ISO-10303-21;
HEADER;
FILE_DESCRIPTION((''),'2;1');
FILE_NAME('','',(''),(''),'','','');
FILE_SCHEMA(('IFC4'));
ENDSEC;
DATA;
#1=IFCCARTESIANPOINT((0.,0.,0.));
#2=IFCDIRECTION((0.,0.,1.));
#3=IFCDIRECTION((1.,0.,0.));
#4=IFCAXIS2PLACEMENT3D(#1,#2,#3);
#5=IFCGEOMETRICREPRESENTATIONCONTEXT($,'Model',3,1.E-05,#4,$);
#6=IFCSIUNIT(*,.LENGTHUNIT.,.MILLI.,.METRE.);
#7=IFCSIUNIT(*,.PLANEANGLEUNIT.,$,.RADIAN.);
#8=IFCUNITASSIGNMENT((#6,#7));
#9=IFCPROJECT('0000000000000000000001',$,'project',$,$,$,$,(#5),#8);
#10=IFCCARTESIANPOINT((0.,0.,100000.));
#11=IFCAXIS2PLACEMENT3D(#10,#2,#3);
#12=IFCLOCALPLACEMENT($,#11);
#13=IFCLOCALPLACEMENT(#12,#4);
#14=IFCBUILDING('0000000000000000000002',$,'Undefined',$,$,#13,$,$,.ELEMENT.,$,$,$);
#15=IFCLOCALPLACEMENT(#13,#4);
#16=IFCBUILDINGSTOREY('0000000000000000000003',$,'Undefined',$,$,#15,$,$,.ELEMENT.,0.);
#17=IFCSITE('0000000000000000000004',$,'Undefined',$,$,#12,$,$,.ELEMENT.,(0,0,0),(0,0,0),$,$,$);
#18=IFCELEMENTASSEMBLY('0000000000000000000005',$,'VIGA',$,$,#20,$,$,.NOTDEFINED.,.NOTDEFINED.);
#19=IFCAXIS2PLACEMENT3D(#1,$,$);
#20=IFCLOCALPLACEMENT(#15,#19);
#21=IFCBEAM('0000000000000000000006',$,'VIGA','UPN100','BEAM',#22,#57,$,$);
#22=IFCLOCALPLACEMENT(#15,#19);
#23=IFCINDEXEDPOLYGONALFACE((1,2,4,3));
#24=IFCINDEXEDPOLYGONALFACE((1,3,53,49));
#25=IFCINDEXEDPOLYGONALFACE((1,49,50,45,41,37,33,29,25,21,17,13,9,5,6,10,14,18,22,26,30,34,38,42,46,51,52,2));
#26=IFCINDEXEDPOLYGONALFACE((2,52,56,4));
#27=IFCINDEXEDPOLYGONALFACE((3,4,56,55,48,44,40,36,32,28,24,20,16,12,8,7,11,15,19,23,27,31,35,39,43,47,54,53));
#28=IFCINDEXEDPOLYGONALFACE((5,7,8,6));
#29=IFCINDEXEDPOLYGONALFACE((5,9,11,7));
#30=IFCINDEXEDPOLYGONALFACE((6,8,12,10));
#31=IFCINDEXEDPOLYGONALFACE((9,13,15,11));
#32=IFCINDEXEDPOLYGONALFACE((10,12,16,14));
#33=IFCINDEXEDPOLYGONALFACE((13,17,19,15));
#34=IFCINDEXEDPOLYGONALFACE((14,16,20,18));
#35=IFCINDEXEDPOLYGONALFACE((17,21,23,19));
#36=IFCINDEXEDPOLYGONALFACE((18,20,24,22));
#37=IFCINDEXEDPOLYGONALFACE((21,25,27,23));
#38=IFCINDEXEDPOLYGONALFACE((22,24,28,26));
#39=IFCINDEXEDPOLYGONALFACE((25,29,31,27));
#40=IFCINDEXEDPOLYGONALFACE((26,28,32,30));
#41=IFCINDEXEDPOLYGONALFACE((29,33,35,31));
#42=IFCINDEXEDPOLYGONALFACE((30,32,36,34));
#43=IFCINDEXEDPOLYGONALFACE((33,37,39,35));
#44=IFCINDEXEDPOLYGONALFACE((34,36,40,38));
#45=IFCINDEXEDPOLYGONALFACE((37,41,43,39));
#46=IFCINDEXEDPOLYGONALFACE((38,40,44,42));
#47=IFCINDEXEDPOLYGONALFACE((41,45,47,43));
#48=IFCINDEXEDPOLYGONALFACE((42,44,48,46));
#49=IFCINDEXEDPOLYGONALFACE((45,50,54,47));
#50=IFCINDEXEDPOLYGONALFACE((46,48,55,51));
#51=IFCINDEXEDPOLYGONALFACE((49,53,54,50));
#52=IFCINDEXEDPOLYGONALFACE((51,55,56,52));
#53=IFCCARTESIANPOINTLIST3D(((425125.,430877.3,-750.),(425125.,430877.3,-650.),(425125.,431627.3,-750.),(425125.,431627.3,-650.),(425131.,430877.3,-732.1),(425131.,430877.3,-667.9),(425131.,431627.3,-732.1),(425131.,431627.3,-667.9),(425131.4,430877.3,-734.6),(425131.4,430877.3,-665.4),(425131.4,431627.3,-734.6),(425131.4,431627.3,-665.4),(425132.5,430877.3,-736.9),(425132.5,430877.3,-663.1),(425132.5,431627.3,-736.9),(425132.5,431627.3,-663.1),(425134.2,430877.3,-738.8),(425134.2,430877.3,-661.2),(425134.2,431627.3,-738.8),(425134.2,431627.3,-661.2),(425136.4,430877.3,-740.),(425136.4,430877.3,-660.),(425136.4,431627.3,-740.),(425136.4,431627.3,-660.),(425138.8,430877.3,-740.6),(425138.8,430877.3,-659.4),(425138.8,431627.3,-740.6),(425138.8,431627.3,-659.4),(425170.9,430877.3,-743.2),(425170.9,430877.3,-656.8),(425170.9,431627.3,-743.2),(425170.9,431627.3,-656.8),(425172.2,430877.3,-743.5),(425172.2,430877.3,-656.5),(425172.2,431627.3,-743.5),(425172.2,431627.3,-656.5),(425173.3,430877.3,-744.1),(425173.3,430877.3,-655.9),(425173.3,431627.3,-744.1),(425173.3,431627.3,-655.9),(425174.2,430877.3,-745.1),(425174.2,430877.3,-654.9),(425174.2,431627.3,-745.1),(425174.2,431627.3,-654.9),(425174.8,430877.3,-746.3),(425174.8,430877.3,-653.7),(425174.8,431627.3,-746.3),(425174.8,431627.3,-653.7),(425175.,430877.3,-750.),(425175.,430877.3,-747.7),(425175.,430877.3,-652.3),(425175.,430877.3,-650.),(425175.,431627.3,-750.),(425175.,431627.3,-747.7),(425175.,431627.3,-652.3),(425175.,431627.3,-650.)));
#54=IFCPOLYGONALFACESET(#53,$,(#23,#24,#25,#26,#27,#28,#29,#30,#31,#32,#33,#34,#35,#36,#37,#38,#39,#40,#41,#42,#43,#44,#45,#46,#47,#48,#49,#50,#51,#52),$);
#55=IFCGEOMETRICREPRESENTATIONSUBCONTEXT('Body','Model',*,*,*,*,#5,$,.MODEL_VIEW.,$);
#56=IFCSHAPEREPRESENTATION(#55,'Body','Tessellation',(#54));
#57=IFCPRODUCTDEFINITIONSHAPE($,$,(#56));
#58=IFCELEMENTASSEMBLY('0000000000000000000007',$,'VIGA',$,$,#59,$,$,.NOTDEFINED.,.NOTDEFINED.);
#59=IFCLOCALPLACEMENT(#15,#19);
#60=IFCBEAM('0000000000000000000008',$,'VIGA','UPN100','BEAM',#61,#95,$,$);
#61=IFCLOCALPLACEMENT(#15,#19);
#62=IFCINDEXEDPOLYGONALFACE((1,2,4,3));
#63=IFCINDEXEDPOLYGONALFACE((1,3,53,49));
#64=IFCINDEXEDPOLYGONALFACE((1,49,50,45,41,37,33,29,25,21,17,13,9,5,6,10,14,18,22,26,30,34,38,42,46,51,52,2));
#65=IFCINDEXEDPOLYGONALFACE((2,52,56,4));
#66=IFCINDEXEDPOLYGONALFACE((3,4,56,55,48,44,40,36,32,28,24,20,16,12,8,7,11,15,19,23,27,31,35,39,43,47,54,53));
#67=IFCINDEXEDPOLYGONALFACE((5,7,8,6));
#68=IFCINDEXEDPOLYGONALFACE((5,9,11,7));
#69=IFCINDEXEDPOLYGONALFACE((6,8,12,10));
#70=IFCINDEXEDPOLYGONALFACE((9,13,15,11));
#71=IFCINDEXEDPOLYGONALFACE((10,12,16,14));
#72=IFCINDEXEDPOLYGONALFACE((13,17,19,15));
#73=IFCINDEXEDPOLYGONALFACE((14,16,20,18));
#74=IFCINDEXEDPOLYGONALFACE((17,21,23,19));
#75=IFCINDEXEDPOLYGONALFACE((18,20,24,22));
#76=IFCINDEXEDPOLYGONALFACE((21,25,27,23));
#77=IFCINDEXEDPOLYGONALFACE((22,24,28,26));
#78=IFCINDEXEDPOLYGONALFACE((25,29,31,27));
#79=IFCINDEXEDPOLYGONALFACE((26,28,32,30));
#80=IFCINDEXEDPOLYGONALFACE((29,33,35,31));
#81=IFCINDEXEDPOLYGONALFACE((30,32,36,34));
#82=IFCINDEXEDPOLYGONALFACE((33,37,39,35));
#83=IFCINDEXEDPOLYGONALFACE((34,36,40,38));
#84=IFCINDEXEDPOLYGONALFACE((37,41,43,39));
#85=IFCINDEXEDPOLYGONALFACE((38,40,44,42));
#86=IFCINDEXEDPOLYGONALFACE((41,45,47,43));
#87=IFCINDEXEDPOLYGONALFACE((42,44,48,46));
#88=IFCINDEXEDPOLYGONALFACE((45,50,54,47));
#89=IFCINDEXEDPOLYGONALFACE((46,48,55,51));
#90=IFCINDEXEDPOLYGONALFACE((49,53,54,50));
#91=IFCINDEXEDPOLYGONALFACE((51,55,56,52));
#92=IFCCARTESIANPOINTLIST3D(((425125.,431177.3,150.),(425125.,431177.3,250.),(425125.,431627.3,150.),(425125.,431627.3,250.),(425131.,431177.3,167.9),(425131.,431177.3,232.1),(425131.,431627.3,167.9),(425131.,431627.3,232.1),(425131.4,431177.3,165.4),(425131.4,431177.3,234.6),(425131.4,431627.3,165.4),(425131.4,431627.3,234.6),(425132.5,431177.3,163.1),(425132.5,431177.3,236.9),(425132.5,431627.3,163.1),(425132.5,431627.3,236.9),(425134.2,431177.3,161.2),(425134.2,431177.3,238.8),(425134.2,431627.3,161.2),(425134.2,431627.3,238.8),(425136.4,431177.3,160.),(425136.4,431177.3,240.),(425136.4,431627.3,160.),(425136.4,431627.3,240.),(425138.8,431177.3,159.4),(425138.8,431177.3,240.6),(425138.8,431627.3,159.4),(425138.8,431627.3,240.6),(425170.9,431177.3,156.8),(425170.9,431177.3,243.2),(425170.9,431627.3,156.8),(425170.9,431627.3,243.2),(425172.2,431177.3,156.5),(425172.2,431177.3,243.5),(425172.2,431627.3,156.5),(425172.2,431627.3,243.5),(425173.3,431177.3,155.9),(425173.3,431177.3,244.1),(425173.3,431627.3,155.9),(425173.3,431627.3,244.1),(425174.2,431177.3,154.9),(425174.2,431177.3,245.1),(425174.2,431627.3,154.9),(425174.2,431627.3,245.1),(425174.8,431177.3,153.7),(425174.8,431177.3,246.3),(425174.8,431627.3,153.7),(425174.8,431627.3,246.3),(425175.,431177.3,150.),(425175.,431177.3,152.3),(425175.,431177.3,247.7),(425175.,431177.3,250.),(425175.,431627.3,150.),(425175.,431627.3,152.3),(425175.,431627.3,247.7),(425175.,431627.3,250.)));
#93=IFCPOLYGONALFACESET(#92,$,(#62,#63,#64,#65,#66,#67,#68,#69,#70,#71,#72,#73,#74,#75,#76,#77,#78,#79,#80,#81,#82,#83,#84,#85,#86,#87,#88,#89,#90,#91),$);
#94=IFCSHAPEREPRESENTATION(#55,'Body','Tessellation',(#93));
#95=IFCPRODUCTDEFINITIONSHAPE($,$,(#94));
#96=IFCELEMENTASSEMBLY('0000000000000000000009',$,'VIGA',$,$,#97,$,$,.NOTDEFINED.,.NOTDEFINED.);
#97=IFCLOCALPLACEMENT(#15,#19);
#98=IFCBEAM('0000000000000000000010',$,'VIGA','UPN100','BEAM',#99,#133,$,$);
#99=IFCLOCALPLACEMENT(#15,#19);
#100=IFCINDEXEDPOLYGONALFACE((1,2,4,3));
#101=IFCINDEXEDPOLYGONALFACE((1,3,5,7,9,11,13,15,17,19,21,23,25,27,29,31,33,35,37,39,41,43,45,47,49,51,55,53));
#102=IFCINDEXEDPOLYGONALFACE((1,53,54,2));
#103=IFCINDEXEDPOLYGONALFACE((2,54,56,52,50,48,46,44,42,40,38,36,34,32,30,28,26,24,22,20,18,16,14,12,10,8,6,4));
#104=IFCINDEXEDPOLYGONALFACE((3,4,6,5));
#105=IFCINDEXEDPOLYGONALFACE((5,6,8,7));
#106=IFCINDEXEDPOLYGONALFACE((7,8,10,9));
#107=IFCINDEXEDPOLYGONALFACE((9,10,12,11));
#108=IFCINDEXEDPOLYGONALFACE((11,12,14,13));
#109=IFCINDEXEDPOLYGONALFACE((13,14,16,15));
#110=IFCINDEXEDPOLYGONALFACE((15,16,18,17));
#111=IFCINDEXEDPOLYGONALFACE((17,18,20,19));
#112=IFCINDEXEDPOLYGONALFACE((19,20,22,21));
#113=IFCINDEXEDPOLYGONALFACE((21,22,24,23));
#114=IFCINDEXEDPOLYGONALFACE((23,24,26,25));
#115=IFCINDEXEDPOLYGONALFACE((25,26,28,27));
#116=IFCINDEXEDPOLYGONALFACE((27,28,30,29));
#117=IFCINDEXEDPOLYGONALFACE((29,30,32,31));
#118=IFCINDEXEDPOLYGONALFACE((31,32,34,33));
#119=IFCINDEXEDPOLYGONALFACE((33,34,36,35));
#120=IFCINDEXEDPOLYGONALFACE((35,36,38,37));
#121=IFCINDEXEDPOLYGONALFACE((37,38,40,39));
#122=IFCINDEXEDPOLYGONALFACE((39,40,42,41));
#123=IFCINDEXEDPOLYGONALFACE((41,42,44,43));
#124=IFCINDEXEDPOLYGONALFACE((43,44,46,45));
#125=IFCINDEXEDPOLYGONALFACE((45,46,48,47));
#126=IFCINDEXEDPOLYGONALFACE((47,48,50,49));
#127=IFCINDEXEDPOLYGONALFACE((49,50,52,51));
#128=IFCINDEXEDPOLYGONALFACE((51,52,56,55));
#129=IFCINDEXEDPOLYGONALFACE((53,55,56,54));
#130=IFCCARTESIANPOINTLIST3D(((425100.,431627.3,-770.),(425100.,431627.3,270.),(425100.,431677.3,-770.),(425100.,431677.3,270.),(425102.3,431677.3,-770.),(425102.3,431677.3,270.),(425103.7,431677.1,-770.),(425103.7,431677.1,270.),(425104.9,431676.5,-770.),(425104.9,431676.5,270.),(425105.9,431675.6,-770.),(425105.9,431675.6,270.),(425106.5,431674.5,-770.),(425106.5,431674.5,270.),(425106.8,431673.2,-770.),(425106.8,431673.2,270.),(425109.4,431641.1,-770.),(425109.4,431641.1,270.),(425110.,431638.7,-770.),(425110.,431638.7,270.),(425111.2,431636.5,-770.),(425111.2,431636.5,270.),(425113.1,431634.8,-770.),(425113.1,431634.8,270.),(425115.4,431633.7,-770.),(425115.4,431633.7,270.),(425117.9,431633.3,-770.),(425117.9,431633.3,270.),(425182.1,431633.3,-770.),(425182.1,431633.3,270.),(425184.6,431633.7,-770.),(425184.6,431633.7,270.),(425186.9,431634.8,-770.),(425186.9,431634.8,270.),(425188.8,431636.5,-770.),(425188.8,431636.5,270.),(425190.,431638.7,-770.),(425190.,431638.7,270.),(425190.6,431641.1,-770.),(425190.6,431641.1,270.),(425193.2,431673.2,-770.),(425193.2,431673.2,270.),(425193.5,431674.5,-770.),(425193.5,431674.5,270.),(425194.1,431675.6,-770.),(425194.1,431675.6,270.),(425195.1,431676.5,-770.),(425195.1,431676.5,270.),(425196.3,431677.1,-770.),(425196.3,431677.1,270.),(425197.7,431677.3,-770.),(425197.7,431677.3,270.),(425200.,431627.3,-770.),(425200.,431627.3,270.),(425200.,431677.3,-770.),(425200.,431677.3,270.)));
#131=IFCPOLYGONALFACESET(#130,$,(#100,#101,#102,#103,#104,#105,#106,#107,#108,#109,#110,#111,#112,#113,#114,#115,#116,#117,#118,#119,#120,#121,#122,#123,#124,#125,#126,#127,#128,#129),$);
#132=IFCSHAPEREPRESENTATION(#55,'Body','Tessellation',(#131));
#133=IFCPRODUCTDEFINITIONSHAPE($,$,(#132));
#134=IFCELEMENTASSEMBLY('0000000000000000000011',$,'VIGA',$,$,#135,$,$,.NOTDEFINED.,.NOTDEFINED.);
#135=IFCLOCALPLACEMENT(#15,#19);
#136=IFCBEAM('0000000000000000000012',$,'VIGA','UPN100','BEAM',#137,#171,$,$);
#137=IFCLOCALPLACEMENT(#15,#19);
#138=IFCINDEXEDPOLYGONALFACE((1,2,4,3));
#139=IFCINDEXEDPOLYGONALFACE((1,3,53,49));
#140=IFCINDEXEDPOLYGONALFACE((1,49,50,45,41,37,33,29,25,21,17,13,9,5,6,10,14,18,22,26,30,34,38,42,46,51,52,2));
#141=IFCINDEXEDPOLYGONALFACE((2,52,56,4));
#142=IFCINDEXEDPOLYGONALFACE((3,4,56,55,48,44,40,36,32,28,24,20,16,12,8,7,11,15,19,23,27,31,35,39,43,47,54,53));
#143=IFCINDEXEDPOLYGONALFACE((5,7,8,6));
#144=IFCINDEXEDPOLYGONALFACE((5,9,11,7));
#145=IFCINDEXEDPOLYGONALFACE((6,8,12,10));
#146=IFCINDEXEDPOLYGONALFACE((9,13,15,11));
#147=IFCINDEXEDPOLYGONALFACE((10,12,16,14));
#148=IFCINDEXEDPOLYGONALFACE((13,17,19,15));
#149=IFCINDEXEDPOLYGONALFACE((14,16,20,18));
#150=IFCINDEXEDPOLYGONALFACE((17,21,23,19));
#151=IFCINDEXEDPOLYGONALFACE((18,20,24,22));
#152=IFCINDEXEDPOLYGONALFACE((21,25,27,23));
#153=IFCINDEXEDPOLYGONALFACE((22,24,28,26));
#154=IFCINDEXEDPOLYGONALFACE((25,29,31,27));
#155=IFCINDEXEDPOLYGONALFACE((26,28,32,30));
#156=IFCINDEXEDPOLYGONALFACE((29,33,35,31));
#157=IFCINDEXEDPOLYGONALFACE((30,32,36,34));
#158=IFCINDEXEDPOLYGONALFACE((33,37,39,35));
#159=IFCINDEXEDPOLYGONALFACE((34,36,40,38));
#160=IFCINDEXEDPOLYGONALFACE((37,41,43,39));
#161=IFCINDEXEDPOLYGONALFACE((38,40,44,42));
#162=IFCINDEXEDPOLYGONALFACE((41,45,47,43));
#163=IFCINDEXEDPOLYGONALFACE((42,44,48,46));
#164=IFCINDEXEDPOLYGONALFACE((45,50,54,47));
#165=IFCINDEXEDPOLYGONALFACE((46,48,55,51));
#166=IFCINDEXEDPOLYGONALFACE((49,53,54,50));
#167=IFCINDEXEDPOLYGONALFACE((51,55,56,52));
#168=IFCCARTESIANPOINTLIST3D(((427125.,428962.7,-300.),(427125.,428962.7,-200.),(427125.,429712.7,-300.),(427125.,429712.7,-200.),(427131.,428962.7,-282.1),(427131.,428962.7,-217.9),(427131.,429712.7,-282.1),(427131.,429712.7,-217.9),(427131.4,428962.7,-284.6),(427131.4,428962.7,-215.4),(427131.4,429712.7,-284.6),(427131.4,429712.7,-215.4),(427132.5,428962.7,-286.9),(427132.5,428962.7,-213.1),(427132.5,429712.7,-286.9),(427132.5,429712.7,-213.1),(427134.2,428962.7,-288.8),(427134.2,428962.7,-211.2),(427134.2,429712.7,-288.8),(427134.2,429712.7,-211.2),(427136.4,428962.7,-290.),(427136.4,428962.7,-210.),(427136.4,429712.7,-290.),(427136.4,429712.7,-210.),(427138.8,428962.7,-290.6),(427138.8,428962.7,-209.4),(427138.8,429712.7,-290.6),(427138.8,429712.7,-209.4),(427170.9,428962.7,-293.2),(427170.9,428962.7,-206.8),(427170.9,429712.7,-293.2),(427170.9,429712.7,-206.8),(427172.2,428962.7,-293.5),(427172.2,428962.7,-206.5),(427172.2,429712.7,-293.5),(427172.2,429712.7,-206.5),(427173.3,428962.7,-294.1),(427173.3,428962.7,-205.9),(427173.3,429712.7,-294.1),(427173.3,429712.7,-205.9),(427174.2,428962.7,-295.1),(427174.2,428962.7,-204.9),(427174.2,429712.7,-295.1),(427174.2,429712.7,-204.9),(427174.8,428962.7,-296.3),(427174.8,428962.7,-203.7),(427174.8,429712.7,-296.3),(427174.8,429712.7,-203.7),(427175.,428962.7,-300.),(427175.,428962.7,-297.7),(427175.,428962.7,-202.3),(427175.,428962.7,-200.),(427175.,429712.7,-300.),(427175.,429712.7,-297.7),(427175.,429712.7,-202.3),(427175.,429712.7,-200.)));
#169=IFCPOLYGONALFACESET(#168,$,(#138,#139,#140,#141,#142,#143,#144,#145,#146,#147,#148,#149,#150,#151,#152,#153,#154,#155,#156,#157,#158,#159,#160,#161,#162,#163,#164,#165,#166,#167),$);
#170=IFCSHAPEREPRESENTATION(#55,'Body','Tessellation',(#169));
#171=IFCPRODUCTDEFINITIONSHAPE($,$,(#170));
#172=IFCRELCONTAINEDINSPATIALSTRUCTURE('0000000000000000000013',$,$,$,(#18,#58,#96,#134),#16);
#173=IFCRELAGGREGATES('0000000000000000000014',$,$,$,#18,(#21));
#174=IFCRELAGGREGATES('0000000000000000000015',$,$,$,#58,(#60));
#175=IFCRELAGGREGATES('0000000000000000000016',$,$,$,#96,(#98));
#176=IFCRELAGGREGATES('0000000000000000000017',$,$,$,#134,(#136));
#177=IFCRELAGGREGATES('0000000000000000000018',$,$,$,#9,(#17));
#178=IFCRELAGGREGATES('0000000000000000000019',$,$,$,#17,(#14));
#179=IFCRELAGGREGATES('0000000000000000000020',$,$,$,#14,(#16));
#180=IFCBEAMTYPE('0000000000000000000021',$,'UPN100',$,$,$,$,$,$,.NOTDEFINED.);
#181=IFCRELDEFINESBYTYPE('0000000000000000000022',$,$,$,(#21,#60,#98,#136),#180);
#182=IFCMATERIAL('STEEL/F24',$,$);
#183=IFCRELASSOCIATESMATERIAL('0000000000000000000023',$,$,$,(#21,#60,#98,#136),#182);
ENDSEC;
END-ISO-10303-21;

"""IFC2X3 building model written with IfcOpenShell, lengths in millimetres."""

from ifc_helpers import new_model, si_unit, frame, origin_with_axes, origin_2d_with_axis, place, context, subcontext, project, spatial, u_section, extrude, material, type_object, element, aggregate, save


model = new_model("IFC2X3")

# Units and contexts
model_context = context("Model", 3, precision=1e-05, world=origin_with_axes())
body_context = subcontext(model_context, "Body", "Model", "MODEL_VIEW")
ifc_project = project(units=[si_unit("LENGTHUNIT", "METRE", prefix="MILLI"), si_unit("PLANEANGLEUNIT", "RADIAN")], contexts=[model_context])

# Site, building, storey
site_placement = place(None, frame((0.0, 0.0, 100000.0), z_axis=(0.0, 0.0, 1.0), x_axis=(1.0, 0.0, 0.0)))
site = spatial("IfcSite", under=ifc_project, at=site_placement, Name="Undefined", CompositionType="ELEMENT", RefLatitude=(0, 0, 0), RefLongitude=(0, 0, 0))
building_placement = place(site_placement, origin_with_axes())
building = spatial("IfcBuilding", under=site, at=building_placement, Name="Undefined", CompositionType="ELEMENT")
storey_placement = place(building_placement, origin_with_axes())
storey = spatial("IfcBuildingStorey", under=building, at=storey_placement, Name="Undefined", CompositionType="ELEMENT", Elevation=0.0)

# Element assemblies, beams
ifc_material_1 = material(Name="STEEL/F24")
beam_type = type_object("IfcBeamType", Name="UPN100", PredefinedType="NOTDEFINED")
assembly_1_placement = place(storey_placement, origin_with_axes())
assembly_1 = element("IfcElementAssembly", 1, at=assembly_1_placement, inside=storey, Name="VIGA", AssemblyPlace="NOTDEFINED", PredefinedType="NOTDEFINED")
beam_1_placement = place(assembly_1_placement, frame((425150.0, 430877.3, -700.0), z_axis=(0.0, 0.0, 1.0), x_axis=(0.0, 1.0, 0.0)))
beam_1 = element("IfcBeam", 2, at=beam_1_placement, type_object=beam_type, material=ifc_material_1, Name="VIGA", Description="UPN100", ObjectType="BEAM", context=body_context, shape_type="SweptSolid", body=[
    extrude(u_section(Depth=100.0, FlangeWidth=50.0, WebThickness=6.0, FlangeThickness=8.5, FilletRadius=8.5, EdgeRadius=4.5, FlangeSlope=0.07983, at=origin_2d_with_axis()), frame((750.0, 0.0, 0.0), z_axis=(-1.0, 0.0, 0.0), x_axis=(0.0, -1.0, 0.0)), (0.0, 0.0, 1.0), 750.0),
])
aggregate(assembly_1, [beam_1])
assembly_2_placement = place(storey_placement, origin_with_axes())
assembly_2 = element("IfcElementAssembly", 3, at=assembly_2_placement, inside=storey, Name="VIGA", AssemblyPlace="NOTDEFINED", PredefinedType="NOTDEFINED")
beam_2_placement = place(assembly_2_placement, frame((425150.0, 431177.3, 200.0), z_axis=(0.0, 0.0, 1.0), x_axis=(0.0, 1.0, 0.0)))
beam_2 = element("IfcBeam", 4, at=beam_2_placement, type_object=beam_type, material=ifc_material_1, Name="VIGA", Description="UPN100", ObjectType="BEAM", context=body_context, shape_type="SweptSolid", body=[
    extrude(u_section(Depth=100.0, FlangeWidth=50.0, WebThickness=6.0, FlangeThickness=8.5, FilletRadius=8.5, EdgeRadius=4.5, FlangeSlope=0.07983, at=origin_2d_with_axis()), frame((450.0, 0.0, 0.0), z_axis=(-1.0, 0.0, 0.0), x_axis=(0.0, -1.0, 0.0)), (0.0, 0.0, 1.0), 450.0),
])
aggregate(assembly_2, [beam_2])
assembly_3_placement = place(storey_placement, origin_with_axes())
assembly_3 = element("IfcElementAssembly", 5, at=assembly_3_placement, inside=storey, Name="VIGA", AssemblyPlace="NOTDEFINED", PredefinedType="NOTDEFINED")
beam_3_placement = place(assembly_3_placement, frame((425150.0, 431652.3, -770.0), z_axis=(1.0, 0.0, 0.0), x_axis=(0.0, 0.0, 1.0)))
beam_3 = element("IfcBeam", 6, at=beam_3_placement, type_object=beam_type, material=ifc_material_1, Name="VIGA", Description="UPN100", ObjectType="BEAM", context=body_context, shape_type="SweptSolid", body=[
    extrude(u_section(Depth=100.0, FlangeWidth=50.0, WebThickness=6.0, FlangeThickness=8.5, FilletRadius=8.5, EdgeRadius=4.5, FlangeSlope=0.07983, at=origin_2d_with_axis()), frame((1040.0, 0.0, 0.0), z_axis=(-1.0, 0.0, 0.0), x_axis=(0.0, -1.0, 0.0)), (0.0, 0.0, 1.0), 1040.0),
])
aggregate(assembly_3, [beam_3])
assembly_4_placement = place(storey_placement, origin_with_axes())
assembly_4 = element("IfcElementAssembly", 7, at=assembly_4_placement, inside=storey, Name="VIGA", AssemblyPlace="NOTDEFINED", PredefinedType="NOTDEFINED")
beam_4_placement = place(assembly_4_placement, frame((427150.0, 428962.7, -250.0), z_axis=(0.0, 0.0, 1.0), x_axis=(0.0, 1.0, 0.0)))
beam_4 = element("IfcBeam", 8, at=beam_4_placement, type_object=beam_type, material=ifc_material_1, Name="VIGA", Description="UPN100", ObjectType="BEAM", context=body_context, shape_type="SweptSolid", body=[
    extrude(u_section(Depth=100.0, FlangeWidth=50.0, WebThickness=6.0, FlangeThickness=8.5, FilletRadius=8.5, EdgeRadius=4.5, FlangeSlope=0.07983, at=origin_2d_with_axis()), frame((750.0, 0.0, 0.0), z_axis=(-1.0, 0.0, 0.0), x_axis=(0.0, -1.0, 0.0)), (0.0, 0.0, 1.0), 750.0),
])
aggregate(assembly_4, [beam_4])

save(model, "model.ifc")
